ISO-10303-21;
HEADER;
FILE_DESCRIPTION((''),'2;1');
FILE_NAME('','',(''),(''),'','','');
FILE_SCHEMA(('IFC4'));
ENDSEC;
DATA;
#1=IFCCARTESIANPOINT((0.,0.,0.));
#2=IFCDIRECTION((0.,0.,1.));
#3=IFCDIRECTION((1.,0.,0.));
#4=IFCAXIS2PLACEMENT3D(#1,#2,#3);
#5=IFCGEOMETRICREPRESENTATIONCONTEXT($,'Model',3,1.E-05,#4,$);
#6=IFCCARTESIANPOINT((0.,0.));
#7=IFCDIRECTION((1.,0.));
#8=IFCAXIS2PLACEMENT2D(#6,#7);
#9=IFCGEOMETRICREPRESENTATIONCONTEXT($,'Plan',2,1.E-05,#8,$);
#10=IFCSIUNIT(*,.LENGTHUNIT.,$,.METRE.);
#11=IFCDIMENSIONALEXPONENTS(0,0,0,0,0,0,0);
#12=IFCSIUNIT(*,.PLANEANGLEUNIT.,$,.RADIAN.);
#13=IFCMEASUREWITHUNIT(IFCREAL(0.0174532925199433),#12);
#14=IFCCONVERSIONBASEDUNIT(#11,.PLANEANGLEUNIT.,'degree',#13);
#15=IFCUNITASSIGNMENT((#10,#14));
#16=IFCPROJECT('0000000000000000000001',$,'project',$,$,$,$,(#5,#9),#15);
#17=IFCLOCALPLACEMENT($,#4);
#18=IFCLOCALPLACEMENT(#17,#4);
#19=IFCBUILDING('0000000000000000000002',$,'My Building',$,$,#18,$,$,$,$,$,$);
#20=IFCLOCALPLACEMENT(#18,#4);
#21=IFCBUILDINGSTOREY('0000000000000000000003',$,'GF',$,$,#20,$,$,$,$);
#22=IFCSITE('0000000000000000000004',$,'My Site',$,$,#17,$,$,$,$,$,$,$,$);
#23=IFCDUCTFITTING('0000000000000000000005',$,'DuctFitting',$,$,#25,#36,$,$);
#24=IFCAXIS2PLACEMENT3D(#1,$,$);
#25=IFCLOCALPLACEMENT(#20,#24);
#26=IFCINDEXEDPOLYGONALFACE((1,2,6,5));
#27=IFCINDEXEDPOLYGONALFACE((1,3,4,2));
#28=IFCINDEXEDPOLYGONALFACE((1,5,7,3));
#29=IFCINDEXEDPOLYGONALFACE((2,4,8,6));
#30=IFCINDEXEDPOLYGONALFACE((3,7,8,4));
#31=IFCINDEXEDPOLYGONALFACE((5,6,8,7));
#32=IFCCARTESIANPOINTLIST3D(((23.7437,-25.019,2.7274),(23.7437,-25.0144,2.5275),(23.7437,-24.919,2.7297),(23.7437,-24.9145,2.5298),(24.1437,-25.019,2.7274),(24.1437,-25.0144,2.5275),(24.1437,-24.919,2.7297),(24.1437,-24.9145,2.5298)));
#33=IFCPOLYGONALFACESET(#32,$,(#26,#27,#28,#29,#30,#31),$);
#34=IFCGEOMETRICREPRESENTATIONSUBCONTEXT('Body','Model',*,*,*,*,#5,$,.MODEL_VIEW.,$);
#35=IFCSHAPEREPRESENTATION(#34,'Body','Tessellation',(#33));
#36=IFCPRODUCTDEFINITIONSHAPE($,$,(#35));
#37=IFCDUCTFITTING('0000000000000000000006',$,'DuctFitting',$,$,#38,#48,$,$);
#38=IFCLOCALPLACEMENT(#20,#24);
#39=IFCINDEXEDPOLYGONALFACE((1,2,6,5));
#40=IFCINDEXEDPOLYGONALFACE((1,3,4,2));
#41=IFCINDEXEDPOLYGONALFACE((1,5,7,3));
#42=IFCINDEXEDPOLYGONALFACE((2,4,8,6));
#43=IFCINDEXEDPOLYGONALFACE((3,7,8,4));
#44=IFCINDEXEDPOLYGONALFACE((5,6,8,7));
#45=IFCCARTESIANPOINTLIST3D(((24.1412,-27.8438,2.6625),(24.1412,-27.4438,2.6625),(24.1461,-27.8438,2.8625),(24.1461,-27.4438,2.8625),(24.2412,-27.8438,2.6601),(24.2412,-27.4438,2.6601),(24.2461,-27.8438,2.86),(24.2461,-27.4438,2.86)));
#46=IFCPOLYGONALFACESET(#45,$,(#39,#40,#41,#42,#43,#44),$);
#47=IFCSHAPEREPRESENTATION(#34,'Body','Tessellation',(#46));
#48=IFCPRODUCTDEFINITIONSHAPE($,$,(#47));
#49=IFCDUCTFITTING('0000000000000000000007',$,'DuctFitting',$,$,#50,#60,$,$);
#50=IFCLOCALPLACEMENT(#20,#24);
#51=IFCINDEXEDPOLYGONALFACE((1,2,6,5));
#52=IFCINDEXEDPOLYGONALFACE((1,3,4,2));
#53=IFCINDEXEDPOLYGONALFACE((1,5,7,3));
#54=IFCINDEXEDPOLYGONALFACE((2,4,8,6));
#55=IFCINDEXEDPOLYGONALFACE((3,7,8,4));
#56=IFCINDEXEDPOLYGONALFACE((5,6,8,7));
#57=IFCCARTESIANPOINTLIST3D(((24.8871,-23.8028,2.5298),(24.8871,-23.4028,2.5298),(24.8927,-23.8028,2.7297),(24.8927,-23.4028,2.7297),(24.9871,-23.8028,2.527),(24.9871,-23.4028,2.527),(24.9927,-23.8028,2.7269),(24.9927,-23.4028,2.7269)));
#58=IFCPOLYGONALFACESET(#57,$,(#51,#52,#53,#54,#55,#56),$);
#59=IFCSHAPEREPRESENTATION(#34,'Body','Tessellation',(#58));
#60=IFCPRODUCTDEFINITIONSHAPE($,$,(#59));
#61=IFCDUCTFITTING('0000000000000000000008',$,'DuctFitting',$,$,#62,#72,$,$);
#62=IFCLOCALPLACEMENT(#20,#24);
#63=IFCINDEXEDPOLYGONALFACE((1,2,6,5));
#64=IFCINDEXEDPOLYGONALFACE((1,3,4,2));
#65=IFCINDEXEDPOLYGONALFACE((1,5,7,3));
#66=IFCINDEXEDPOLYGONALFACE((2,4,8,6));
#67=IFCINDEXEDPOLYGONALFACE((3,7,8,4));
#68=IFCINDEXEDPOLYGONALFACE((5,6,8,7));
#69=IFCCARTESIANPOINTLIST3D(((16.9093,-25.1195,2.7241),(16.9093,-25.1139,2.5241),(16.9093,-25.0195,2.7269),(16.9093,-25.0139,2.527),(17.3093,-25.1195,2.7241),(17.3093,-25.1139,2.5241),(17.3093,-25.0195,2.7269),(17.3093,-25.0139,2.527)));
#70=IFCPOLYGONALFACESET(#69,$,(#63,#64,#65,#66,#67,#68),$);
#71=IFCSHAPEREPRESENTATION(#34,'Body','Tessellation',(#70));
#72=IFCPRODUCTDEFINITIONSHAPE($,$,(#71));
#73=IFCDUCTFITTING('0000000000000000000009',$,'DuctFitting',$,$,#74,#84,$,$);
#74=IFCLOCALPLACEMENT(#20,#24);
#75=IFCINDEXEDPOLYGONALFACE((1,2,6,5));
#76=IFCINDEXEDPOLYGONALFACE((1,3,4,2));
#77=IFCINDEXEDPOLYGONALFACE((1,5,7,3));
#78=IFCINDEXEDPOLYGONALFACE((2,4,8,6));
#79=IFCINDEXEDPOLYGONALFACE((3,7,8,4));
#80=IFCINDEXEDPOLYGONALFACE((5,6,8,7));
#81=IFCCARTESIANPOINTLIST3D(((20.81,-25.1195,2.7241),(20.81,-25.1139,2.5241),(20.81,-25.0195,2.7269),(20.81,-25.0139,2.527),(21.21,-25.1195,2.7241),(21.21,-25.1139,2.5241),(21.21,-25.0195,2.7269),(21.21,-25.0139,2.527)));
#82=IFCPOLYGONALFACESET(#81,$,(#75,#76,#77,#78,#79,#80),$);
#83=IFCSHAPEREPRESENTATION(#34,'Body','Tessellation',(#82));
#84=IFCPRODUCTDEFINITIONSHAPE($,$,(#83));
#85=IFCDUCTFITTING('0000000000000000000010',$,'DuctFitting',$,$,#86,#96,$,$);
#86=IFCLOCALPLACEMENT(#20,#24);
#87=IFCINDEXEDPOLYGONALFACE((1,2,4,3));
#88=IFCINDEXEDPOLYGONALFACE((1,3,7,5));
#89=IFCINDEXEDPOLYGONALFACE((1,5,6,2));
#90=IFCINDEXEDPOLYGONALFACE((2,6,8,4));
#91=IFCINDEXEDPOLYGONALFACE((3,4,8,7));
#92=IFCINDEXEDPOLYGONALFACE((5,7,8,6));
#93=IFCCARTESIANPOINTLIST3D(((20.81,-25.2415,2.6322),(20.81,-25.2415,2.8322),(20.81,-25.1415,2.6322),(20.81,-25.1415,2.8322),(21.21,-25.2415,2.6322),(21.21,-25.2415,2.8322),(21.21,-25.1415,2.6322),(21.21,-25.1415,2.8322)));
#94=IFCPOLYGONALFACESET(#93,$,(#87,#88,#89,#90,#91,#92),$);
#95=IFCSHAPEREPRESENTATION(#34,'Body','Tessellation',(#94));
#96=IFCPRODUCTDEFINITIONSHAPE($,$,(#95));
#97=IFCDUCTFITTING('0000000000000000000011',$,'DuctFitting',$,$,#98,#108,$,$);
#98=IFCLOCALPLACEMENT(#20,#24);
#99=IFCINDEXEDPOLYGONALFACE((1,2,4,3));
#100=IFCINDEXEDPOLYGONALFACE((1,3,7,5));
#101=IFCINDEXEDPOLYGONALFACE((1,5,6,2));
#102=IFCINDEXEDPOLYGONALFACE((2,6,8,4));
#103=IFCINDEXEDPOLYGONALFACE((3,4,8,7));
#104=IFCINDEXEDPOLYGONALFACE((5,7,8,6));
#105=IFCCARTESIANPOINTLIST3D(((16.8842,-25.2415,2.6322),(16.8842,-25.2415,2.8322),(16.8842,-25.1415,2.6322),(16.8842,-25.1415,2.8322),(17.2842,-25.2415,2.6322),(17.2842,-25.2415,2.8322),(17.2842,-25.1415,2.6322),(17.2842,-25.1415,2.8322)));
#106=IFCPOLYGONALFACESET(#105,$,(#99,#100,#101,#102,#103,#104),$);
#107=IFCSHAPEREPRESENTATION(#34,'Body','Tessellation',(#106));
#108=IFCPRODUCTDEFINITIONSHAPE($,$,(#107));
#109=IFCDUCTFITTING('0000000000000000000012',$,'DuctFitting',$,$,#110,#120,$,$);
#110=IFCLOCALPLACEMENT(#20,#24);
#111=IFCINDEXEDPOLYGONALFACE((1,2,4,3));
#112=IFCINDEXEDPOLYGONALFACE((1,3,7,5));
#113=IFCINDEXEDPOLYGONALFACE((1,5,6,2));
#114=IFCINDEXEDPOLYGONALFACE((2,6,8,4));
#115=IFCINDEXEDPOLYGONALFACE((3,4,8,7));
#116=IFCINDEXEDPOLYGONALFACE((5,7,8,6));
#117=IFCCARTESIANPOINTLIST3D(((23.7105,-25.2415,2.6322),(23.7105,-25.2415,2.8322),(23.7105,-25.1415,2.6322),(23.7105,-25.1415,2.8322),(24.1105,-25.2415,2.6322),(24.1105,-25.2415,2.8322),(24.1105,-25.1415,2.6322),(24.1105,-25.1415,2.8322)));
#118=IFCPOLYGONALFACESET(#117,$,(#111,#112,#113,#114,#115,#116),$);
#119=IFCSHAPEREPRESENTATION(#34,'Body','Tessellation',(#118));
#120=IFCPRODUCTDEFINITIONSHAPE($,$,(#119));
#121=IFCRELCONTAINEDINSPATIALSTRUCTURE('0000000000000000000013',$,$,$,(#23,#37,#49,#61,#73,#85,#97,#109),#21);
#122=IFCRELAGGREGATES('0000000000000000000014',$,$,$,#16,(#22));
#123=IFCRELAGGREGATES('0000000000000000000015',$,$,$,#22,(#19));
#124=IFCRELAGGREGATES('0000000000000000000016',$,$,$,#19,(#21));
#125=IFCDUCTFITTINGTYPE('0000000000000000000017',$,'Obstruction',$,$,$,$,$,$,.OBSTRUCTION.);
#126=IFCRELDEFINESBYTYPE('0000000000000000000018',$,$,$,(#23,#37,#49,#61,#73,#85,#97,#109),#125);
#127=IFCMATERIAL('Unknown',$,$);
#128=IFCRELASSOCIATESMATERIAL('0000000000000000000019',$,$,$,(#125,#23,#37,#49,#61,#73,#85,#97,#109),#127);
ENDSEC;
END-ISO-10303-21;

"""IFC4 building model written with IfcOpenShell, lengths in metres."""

from ifc_helpers import new_model, entity, si_unit, converted_unit, frame, origin_with_axes, origin_2d_with_axis, place, context, subcontext, project, spatial, rectangle, extrude, material, material_profile, profile_set, profile_usage, type_object, element, save


model = new_model("IFC4")

# Units and contexts
model_context = context("Model", 3, precision=1e-05, world=origin_with_axes())
plan_context = context("Plan", 2, precision=1e-05, world=origin_2d_with_axis())
body_context = subcontext(model_context, "Body", "Model", "MODEL_VIEW")
ifc_project = project(units=[si_unit("LENGTHUNIT", "METRE"), converted_unit("PLANEANGLEUNIT", "degree", entity("IfcReal", 0.0174532925199433), si_unit("PLANEANGLEUNIT", "RADIAN"), dimensions=[0, 0, 0, 0, 0, 0, 0])], contexts=[model_context, plan_context])

# Site, building, storey
site_placement = place(None, origin_with_axes())
site = spatial("IfcSite", under=ifc_project, at=site_placement, Name="My Site")
building_placement = place(site_placement, origin_with_axes())
building = spatial("IfcBuilding", under=site, at=building_placement, Name="My Building")
storey_placement = place(building_placement, origin_with_axes())
storey = spatial("IfcBuildingStorey", under=building, at=storey_placement, Name="GF")

# Shared definitions
ifc_material = material(Name="Unknown")

# Duct fittings
ifc_material_profile_1 = material_profile(ifc_material, rectangle(XDim=0.4, YDim=0.2))
ifc_profile_set_1 = profile_set([ifc_material_profile_1])
duct_fitting_type_1 = type_object("IfcDuctFittingType", Name="Obstruction", PredefinedType="OBSTRUCTION", material=ifc_profile_set_1)
ifc_profile_usage_1 = profile_usage(ifc_profile_set_1, cardinal=5)
duct_fitting_1_placement = place(storey_placement, frame((23.9437, -24.9167, 2.6297), z_axis=(0.0, -0.999736, -0.022998), x_axis=(1.0, 0.0, 0.0)))
element("IfcDuctFitting", 1, at=duct_fitting_1_placement, inside=storey, type_object=duct_fitting_type_1, material=ifc_profile_usage_1, Name="DuctFitting", context=body_context, shape_type="SweptSolid", body=[
    extrude(rectangle(XDim=0.4, YDim=0.2), origin_with_axes(), (0.0, 0.0, 1.0), 0.1),
])
ifc_profile_usage_2 = profile_usage(ifc_profile_set_1, cardinal=5)
duct_fitting_2_placement = place(storey_placement, frame((24.1437, -27.6438, 2.7625), z_axis=(0.9997, 0.0, -0.024499), x_axis=(0.0, 1.0, 0.0)))
element("IfcDuctFitting", 2, at=duct_fitting_2_placement, inside=storey, type_object=duct_fitting_type_1, material=ifc_profile_usage_2, Name="DuctFitting", context=body_context, shape_type="SweptSolid", body=[
    extrude(rectangle(XDim=0.4, YDim=0.2), origin_with_axes(), (0.0, 0.0, 1.0), 0.1),
])
ifc_profile_usage_3 = profile_usage(ifc_profile_set_1, cardinal=5)
duct_fitting_3_placement = place(storey_placement, frame((24.8899, -23.6028, 2.6297), z_axis=(0.999605, 0.0, -0.02812), x_axis=(0.0, 1.0, 0.0)))
element("IfcDuctFitting", 3, at=duct_fitting_3_placement, inside=storey, type_object=duct_fitting_type_1, material=ifc_profile_usage_3, Name="DuctFitting", context=body_context, shape_type="SweptSolid", body=[
    extrude(rectangle(XDim=0.4, YDim=0.2), origin_with_axes(), (0.0, 0.0, 1.0), 0.1),
])
ifc_profile_usage_4 = profile_usage(ifc_profile_set_1, cardinal=5)
duct_fitting_4_placement = place(storey_placement, frame((17.1093, -25.0167, 2.6269), z_axis=(0.0, -0.999605, -0.02812), x_axis=(1.0, 0.0, 0.0)))
element("IfcDuctFitting", 4, at=duct_fitting_4_placement, inside=storey, type_object=duct_fitting_type_1, material=ifc_profile_usage_4, Name="DuctFitting", context=body_context, shape_type="SweptSolid", body=[
    extrude(rectangle(XDim=0.4, YDim=0.2), origin_with_axes(), (0.0, 0.0, 1.0), 0.1),
])
ifc_profile_usage_5 = profile_usage(ifc_profile_set_1, cardinal=5)
duct_fitting_5_placement = place(storey_placement, frame((21.01, -25.0167, 2.6269), z_axis=(0.0, -0.999605, -0.02812), x_axis=(1.0, 0.0, 0.0)))
element("IfcDuctFitting", 5, at=duct_fitting_5_placement, inside=storey, type_object=duct_fitting_type_1, material=ifc_profile_usage_5, Name="DuctFitting", context=body_context, shape_type="SweptSolid", body=[
    extrude(rectangle(XDim=0.4, YDim=0.2), origin_with_axes(), (0.0, 0.0, 1.0), 0.1),
])
ifc_profile_usage_6 = profile_usage(ifc_profile_set_1, cardinal=5)
duct_fitting_6_placement = place(storey_placement, frame((21.01, -25.1415, 2.7322), z_axis=(0.0, -1.0, 0.0), x_axis=(1.0, 0.0, 0.0)))
element("IfcDuctFitting", 6, at=duct_fitting_6_placement, inside=storey, type_object=duct_fitting_type_1, material=ifc_profile_usage_6, Name="DuctFitting", context=body_context, shape_type="SweptSolid", body=[
    extrude(rectangle(XDim=0.4, YDim=0.2), origin_with_axes(), (0.0, 0.0, 1.0), 0.1),
])
ifc_profile_usage_7 = profile_usage(ifc_profile_set_1, cardinal=5)
duct_fitting_7_placement = place(storey_placement, frame((17.0842, -25.1415, 2.7322), z_axis=(0.0, -1.0, 0.0), x_axis=(1.0, 0.0, 0.0)))
element("IfcDuctFitting", 7, at=duct_fitting_7_placement, inside=storey, type_object=duct_fitting_type_1, material=ifc_profile_usage_7, Name="DuctFitting", context=body_context, shape_type="SweptSolid", body=[
    extrude(rectangle(XDim=0.4, YDim=0.2), origin_with_axes(), (0.0, 0.0, 1.0), 0.1),
])
ifc_profile_usage_8 = profile_usage(ifc_profile_set_1, cardinal=5)
duct_fitting_8_placement = place(storey_placement, frame((23.9105, -25.1415, 2.7322), z_axis=(0.0, -1.0, 0.0), x_axis=(1.0, 0.0, 0.0)))
element("IfcDuctFitting", 8, at=duct_fitting_8_placement, inside=storey, type_object=duct_fitting_type_1, material=ifc_profile_usage_8, Name="DuctFitting", context=body_context, shape_type="SweptSolid", body=[
    extrude(rectangle(XDim=0.4, YDim=0.2), origin_with_axes(), (0.0, 0.0, 1.0), 0.1),
])

save(model, "model.ifc")
